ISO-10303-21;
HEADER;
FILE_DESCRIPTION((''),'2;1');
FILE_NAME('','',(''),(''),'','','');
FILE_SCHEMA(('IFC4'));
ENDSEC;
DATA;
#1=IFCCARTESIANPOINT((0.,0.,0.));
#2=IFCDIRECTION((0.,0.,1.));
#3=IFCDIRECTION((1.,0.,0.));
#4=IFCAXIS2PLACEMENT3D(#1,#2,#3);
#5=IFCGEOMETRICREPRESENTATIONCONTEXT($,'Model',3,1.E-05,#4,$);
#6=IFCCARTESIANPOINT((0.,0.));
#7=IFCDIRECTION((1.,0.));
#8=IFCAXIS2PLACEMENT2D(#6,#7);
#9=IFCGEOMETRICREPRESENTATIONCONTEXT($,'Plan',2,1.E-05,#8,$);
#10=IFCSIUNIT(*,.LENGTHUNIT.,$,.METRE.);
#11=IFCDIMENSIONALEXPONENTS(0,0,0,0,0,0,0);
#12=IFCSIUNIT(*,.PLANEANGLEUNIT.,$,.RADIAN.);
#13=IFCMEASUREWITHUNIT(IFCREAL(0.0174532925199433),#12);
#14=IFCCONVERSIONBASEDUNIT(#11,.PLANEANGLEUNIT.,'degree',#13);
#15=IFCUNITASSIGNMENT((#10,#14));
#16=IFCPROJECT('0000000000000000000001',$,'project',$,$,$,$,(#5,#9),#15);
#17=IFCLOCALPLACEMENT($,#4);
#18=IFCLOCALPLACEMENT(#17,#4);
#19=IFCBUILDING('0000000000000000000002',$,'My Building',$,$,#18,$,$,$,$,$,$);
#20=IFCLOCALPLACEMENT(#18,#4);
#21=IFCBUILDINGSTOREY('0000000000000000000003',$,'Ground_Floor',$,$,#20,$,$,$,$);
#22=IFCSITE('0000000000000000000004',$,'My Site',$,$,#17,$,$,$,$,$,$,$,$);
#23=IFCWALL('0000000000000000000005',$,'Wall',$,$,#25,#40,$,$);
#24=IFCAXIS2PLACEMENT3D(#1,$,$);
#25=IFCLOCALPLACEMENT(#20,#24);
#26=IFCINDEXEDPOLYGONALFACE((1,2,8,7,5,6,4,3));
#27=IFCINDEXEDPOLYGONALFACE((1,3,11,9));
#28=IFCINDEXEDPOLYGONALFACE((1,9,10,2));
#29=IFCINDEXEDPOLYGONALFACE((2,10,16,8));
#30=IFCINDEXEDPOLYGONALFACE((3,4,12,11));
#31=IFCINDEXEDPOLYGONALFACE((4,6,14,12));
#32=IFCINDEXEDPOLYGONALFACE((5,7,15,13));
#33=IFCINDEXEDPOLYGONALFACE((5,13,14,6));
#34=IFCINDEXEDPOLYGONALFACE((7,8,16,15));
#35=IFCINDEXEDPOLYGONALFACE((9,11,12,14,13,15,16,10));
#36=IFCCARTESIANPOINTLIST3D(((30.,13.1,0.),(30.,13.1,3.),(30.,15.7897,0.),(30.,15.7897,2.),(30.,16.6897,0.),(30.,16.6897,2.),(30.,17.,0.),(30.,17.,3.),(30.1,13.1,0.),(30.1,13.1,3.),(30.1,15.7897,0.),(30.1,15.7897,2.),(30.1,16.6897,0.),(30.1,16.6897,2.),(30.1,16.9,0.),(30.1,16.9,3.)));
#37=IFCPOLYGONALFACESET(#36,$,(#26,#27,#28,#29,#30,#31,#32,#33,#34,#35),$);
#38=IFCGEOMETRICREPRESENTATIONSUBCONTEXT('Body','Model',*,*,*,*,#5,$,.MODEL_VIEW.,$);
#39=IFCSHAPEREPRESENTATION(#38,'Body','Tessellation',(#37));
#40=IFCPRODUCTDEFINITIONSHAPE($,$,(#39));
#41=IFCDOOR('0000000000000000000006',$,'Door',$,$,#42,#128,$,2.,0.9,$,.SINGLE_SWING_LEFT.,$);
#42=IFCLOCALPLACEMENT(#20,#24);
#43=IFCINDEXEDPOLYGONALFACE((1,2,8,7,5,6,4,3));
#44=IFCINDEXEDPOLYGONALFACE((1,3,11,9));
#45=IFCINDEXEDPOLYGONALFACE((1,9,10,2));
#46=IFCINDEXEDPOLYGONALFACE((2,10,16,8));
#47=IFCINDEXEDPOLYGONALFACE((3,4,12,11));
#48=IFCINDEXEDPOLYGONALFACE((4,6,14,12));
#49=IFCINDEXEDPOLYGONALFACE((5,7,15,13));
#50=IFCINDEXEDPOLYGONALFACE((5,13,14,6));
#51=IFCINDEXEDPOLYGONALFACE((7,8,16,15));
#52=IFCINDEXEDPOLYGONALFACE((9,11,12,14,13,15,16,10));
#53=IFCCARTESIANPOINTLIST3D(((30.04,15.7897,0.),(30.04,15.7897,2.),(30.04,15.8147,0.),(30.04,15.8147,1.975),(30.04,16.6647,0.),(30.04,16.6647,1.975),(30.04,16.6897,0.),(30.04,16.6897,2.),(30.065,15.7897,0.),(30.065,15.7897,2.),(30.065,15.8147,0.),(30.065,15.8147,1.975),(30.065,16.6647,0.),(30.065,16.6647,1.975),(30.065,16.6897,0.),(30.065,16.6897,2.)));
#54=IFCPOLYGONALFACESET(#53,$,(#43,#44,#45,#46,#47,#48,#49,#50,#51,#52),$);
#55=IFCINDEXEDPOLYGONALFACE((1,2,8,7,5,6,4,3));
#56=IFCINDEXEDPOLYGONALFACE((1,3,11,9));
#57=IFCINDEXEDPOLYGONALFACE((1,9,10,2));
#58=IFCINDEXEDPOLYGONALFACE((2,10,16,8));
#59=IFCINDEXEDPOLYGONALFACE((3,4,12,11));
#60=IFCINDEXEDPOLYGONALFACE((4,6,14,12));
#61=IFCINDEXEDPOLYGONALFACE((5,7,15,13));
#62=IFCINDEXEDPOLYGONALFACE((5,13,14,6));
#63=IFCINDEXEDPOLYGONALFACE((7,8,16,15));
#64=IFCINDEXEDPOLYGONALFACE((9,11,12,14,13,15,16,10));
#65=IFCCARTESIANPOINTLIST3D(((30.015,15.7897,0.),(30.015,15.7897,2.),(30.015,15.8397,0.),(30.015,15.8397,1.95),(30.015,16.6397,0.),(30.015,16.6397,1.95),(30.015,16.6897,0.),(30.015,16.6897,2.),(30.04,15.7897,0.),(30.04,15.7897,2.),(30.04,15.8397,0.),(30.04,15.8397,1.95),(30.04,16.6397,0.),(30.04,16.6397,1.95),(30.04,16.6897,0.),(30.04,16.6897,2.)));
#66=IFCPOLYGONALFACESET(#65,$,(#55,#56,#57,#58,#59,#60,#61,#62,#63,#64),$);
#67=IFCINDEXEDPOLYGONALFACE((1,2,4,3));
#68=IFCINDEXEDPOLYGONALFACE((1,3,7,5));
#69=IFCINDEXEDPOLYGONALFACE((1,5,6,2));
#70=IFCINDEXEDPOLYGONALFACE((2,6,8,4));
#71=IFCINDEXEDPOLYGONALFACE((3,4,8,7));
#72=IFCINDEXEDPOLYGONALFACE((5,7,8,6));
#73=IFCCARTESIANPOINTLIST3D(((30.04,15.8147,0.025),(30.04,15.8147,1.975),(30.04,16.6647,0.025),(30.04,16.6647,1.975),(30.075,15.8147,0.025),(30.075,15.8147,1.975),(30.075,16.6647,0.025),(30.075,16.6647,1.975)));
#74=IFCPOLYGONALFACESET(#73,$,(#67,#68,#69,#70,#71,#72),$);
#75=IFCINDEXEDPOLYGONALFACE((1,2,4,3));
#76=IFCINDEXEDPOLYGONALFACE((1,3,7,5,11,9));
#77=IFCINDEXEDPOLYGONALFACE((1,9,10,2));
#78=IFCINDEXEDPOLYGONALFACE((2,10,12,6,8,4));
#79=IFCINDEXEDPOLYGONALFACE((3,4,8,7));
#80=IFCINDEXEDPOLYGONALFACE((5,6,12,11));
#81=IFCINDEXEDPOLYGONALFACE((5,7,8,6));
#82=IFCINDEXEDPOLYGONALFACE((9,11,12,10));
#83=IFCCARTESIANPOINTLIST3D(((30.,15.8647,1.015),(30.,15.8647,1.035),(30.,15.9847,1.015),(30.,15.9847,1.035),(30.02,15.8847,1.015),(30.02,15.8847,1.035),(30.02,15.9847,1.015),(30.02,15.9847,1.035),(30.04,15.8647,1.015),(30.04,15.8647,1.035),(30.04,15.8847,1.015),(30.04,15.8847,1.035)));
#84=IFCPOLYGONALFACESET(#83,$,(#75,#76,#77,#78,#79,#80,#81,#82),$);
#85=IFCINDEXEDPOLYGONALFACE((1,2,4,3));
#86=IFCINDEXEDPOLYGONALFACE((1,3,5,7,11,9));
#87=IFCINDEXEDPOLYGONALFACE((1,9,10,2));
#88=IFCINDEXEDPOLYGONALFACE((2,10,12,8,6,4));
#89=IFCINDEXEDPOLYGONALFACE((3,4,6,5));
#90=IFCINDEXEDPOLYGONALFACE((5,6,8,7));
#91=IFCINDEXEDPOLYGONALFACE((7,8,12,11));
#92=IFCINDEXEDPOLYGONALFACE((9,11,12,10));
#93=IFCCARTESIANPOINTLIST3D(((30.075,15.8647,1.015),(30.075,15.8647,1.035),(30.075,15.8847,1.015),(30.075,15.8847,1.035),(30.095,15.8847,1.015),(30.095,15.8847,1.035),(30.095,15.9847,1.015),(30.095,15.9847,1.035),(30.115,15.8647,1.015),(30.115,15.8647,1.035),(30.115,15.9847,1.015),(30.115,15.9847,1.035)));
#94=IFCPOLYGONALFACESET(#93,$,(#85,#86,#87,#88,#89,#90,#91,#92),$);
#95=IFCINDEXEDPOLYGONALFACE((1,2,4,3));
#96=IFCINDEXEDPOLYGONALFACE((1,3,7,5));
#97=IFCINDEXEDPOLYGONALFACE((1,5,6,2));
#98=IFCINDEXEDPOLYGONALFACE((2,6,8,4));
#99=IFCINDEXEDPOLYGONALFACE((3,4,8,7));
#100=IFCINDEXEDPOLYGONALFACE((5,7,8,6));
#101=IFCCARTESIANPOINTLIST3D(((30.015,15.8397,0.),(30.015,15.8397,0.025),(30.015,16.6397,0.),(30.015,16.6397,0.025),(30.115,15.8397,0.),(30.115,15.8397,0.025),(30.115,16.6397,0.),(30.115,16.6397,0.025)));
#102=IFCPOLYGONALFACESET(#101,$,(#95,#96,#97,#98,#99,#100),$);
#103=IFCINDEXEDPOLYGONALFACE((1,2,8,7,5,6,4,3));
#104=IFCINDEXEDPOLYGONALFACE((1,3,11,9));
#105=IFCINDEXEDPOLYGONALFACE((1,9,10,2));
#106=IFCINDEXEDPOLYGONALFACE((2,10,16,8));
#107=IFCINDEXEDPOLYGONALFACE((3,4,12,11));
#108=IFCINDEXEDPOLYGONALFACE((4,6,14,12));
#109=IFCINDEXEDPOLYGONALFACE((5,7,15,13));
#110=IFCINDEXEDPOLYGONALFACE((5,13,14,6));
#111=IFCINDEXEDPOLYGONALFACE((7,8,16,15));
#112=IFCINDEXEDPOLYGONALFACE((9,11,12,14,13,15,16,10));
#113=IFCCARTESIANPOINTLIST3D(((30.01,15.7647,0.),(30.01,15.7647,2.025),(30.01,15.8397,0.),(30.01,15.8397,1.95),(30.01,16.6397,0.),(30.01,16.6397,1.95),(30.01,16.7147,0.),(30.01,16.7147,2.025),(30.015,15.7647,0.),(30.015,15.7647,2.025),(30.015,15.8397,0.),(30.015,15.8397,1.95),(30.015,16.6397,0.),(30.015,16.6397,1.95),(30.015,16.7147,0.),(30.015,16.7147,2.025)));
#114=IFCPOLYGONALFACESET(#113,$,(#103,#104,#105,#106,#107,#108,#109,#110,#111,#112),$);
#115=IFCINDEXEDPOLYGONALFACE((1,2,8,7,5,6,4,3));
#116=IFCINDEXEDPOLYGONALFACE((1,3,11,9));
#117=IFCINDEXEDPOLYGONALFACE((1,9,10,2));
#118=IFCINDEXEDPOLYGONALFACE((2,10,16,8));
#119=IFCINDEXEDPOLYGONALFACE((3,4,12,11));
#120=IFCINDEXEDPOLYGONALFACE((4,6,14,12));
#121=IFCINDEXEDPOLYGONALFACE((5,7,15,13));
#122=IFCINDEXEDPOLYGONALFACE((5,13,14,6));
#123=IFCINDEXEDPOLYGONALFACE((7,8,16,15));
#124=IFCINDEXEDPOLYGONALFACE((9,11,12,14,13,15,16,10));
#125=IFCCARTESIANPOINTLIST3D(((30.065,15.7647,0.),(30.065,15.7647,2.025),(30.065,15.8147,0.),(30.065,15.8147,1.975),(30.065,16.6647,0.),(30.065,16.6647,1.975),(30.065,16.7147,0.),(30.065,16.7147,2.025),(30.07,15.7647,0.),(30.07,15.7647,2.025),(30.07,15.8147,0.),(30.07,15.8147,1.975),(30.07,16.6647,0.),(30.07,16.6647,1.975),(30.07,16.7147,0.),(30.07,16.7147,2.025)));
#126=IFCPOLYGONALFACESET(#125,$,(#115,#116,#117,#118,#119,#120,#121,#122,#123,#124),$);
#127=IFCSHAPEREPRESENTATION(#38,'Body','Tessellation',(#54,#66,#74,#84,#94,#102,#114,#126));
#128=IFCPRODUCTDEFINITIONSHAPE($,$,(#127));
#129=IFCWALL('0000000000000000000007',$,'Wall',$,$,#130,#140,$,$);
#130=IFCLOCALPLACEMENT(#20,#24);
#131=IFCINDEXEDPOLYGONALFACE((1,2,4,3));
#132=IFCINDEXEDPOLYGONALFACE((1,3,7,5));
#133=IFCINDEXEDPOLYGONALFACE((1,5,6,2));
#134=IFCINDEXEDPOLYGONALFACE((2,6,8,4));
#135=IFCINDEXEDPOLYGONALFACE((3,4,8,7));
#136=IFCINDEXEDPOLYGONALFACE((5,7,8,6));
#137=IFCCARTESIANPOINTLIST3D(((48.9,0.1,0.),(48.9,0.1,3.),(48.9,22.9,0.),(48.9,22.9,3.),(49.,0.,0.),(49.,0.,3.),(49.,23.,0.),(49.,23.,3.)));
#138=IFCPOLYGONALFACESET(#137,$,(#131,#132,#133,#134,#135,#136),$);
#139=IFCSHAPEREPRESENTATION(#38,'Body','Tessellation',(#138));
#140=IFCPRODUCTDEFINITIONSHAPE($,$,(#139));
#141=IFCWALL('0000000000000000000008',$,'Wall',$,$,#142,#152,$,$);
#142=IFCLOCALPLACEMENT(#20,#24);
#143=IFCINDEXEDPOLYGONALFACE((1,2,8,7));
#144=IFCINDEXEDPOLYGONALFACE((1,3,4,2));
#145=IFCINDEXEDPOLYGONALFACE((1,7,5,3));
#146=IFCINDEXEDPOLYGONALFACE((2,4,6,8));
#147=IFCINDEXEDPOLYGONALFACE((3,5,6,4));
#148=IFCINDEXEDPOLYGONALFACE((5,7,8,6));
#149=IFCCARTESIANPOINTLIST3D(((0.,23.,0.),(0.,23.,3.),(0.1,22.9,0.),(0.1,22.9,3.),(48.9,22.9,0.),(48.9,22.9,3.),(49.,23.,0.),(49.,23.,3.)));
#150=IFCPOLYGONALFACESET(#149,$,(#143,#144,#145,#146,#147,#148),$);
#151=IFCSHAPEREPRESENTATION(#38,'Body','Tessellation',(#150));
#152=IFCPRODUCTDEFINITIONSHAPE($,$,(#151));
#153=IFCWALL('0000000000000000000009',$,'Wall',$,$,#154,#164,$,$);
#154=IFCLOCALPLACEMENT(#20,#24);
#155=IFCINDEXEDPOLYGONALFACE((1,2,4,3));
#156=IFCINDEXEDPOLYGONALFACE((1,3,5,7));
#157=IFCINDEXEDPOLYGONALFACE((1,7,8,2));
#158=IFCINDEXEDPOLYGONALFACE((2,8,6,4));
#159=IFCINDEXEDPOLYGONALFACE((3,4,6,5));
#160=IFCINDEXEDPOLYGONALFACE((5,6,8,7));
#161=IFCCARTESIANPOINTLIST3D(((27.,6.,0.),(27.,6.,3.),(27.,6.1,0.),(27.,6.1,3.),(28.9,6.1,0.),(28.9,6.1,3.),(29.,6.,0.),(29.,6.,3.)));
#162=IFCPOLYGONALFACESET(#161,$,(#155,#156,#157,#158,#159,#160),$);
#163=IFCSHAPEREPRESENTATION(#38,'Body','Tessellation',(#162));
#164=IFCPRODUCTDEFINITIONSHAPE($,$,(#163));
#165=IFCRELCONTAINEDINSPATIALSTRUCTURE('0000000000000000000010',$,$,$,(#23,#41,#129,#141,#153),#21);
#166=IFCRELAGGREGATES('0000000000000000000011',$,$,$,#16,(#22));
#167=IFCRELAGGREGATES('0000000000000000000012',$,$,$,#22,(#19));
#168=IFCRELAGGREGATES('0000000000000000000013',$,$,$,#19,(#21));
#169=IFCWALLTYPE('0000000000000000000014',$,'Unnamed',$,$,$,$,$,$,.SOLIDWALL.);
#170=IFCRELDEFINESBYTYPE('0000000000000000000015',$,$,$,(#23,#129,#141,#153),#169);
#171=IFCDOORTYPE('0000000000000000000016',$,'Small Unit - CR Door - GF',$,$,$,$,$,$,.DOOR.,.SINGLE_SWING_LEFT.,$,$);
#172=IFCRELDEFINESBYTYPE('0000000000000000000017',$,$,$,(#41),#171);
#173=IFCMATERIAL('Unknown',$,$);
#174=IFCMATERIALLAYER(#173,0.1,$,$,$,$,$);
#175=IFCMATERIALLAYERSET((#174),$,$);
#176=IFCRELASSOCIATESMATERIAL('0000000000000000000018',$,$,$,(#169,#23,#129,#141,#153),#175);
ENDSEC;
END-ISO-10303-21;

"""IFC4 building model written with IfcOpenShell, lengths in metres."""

from ifc_helpers import new_model, entity, si_unit, converted_unit, frame, origin_with_axes, origin_2d_with_axis, place, context, subcontext, project, spatial, line, indexed_curve, outline, extrude, shape, source, transform, mapped, material, layer, layer_set, layer_usage, type_object, type_shapes, element, fill, save


model = new_model("IFC4")

# Units and contexts
model_context = context("Model", 3, precision=1e-05, world=origin_with_axes())
plan_context = context("Plan", 2, precision=1e-05, world=origin_2d_with_axis())
body_context_1 = subcontext(model_context, "Body", "Model", "MODEL_VIEW")
body_context_2 = subcontext(plan_context, "Body", "Plan", "PLAN_VIEW")
ifc_project = project(units=[si_unit("LENGTHUNIT", "METRE"), converted_unit("PLANEANGLEUNIT", "degree", entity("IfcReal", 0.0174532925199433), si_unit("PLANEANGLEUNIT", "RADIAN"), dimensions=[0, 0, 0, 0, 0, 0, 0])], contexts=[model_context, plan_context])

# Site, building, storey
site_placement = place(None, origin_with_axes())
site = spatial("IfcSite", under=ifc_project, at=site_placement, Name="My Site")
building_placement = place(site_placement, origin_with_axes())
building = spatial("IfcBuilding", under=site, at=building_placement, Name="My Building")
storey_placement = place(building_placement, origin_with_axes())
storey = spatial("IfcBuildingStorey", under=building, at=storey_placement, Name="Ground_Floor")

# Shared definitions
ifc_material = material(Name="Unknown")
ifc_layer = layer(ifc_material, 0.1)
ifc_layer_set = layer_set([ifc_layer])
wall_type = type_object("IfcWallType", Name="Unnamed", PredefinedType="SOLIDWALL", material=ifc_layer_set)

# Shared definitions
shared_shape_1 = source(origin_with_axes(), body_context_1, "Body", "SweptSolid", [
    extrude(outline(indexed_curve([(0.0, 0.0), (0.9, 0.0), (0.9, 2.0), (0.0, 2.0)], segments=[line(1, 2, 3, 4, 1)])), frame((0.0, -0.6, 0.0), z_axis=(0.0, -1.0, 0.0), x_axis=(1.0, 0.0, 0.0)), (0.0, 0.0, -1.0), 1.2),
])
door_type_1 = type_object("IfcDoorType", Name="Small Unit - CR Door - GF", OperationType="SINGLE_SWING_LEFT", PredefinedType="DOOR")
shared_shape_2 = source(origin_with_axes(), body_context_1, "Body", "SweptSolid", [
    extrude(outline(indexed_curve([(0.0, 0.0), (0.0, 2.0), (0.9, 2.0), (0.9, 0.0), (0.875, 0.0), (0.875, 1.975), (0.025, 1.975), (0.025, 0.0)], segments=[line(1, 2, 3, 4, 5, 6, 7, 8, 1)])), frame((0.0, 0.025, 0.0), z_axis=(0.0, -1.0, 0.0), x_axis=(1.0, 0.0, 0.0)), (0.0, 0.0, -1.0), 0.025),
    extrude(outline(indexed_curve([(0.0, 0.0), (0.0, 2.0), (0.9, 2.0), (0.9, 0.0), (0.85, 0.0), (0.85, 1.95), (0.05, 1.95), (0.05, 0.0)], segments=[line(1, 2, 3, 4, 5, 6, 7, 8, 1)])), frame((0.0, 0.0, 0.0), z_axis=(0.0, -1.0, 0.0), x_axis=(1.0, 0.0, 0.0)), (0.0, 0.0, -1.0), 0.025),
    extrude(outline(indexed_curve([(0.0, 0.0), (0.85, 0.0), (0.85, 0.035), (0.0, 0.035)], segments=[line(1, 2, 3, 4, 1)])), frame((0.025, 0.025, 0.025), z_axis=(0.0, 0.0, 1.0), x_axis=(1.0, 0.0, 0.0)), (0.0, 0.0, 1.0), 1.95),
    extrude(outline(indexed_curve([(0.0, 0.0), (0.0, -0.04), (-0.12, -0.04), (-0.12, -0.02), (-0.02, -0.02), (-0.02, 0.0)], segments=[line(1, 2, 3, 4, 5, 6, 1)])), frame((0.825, 0.025, 1.015), z_axis=(0.0, 0.0, 1.0), x_axis=(1.0, 0.0, 0.0)), (0.0, 0.0, 1.0), 0.02),
    extrude(outline(indexed_curve([(0.0, 0.0), (0.0, 0.04), (-0.12, 0.04), (-0.12, 0.02), (-0.02, 0.02), (-0.02, 0.0)], segments=[line(1, 2, 3, 4, 5, 6, 1)])), frame((0.825, 0.06, 1.015), z_axis=(0.0, 0.0, 1.0), x_axis=(1.0, 0.0, 0.0)), (0.0, 0.0, 1.0), 0.02),
    extrude(outline(indexed_curve([(0.0, 0.0), (0.8, 0.0), (0.8, 0.1), (0.0, 0.1)], segments=[line(1, 2, 3, 4, 1)])), frame((0.05, 0.0, 0.0), z_axis=(0.0, 0.0, 1.0), x_axis=(1.0, 0.0, 0.0)), (0.0, 0.0, 1.0), 0.025),
    extrude(outline(indexed_curve([(0.0, 0.0), (0.0, 2.025), (0.95, 2.025), (0.95, 0.0), (0.875, 0.0), (0.875, 1.95), (0.075, 1.95), (0.075, 0.0)], segments=[line(1, 2, 3, 4, 5, 6, 7, 8, 1)])), frame((-0.025, -0.005, 0.0), z_axis=(0.0, -1.0, 0.0), x_axis=(1.0, 0.0, 0.0)), (0.0, 0.0, -1.0), 0.005),
    extrude(outline(indexed_curve([(0.0, 0.0), (0.0, 2.025), (0.95, 2.025), (0.95, 0.0), (0.9, 0.0), (0.9, 1.975), (0.05, 1.975), (0.05, 0.0)], segments=[line(1, 2, 3, 4, 5, 6, 7, 8, 1)])), frame((-0.025, 0.05, 0.0), z_axis=(0.0, -1.0, 0.0), x_axis=(1.0, 0.0, 0.0)), (0.0, 0.0, -1.0), 0.005),
])
shared_shape_3 = source(origin_with_axes(), body_context_2, "Body", "Curve2D", [
    entity("IfcIndexedPolyCurve", entity("IfcCartesianPointList2D", [[0.0, 0.0], [0.0, 0.05], [0.025, 0.05], [0.025, 0.025], [0.05, 0.025], [0.05, 0.0]]), [entity("IfcLineIndex", [1, 2, 3, 4, 5, 6, 1])]),
    entity("IfcIndexedPolyCurve", entity("IfcCartesianPointList2D", [[0.9, 0.0], [0.9, 0.05], [0.875, 0.05], [0.875, 0.025], [0.85, 0.025], [0.85, 0.0]]), [entity("IfcLineIndex", [1, 2, 3, 4, 5, 6, 1])]),
    entity("IfcTrimmedCurve", entity("IfcEllipse", entity("IfcAxis2Placement2D", entity("IfcCartesianPoint", [0.06, 0.05]), entity("IfcDirection", [1.0, 0.0])), 0.815, 0.85), [entity("IfcCartesianPoint", [0.875, 0.05])], [entity("IfcCartesianPoint", [0.06, 0.9])], True, "CARTESIAN"),
    entity("IfcIndexedPolyCurve", entity("IfcCartesianPointList2D", [[0.025, 0.05], [0.06, 0.05], [0.06, 0.9], [0.025, 0.9]]), [entity("IfcLineIndex", [1, 2, 3, 4, 1])]),
])
type_shapes(door_type_1, [shared_shape_2, shared_shape_3])

# Wall, opening, door
ifc_layer_usage_1 = layer_usage(ifc_layer_set, "AXIS2", "POSITIVE", 0.0)
wall_1_placement = place(storey_placement, frame((30.0, 17.0, 0.0), z_axis=(0.0, 0.0, 1.0), x_axis=(0.0, -1.0, 0.0)))
wall_1 = element("IfcWall", 1, at=wall_1_placement, inside=storey, type_object=wall_type, material=ifc_layer_usage_1, Name="Wall", context=body_context_1, shape_type="SweptSolid", body=[
    extrude(outline(indexed_curve([(0.0, 0.0), (0.1, 0.1), (3.9, 0.1), (3.9, 0.0)], segments=[line(1, 2, 3, 4, 1)])), origin_with_axes(), (0.0, 0.0, 1.0), 3.0),
])
opening_1_placement = place(wall_1_placement, frame((0.3103, 0.015, 0.0), z_axis=(0.0, 0.0, 1.0), x_axis=(1.0, 0.0, 0.0)))
opening_1 = element("IfcOpeningElement", 2, at=opening_1_placement, cuts=wall_1, PredefinedType="OPENING", context=body_context_1, shape_type="MappedRepresentation", body=[
    mapped(shared_shape_1, transform((0.0, 0.0, 0.0), x_axis=(1.0, 0.0, 0.0), y_axis=(0.0, 1.0, 0.0), z_axis=(0.0, 0.0, 1.0), scale=1.0)),
])
door_1_placement = place(opening_1_placement, frame((0.0, 0.0, 0.0), z_axis=(0.0, 0.0, 1.0), x_axis=(1.0, 0.0, 0.0)))
door_1 = element("IfcDoor", 3, at=door_1_placement, inside=storey, type_object=door_type_1, Name="Door", OperationType="SINGLE_SWING_LEFT", OverallHeight=2.0, OverallWidth=0.9, shapes=[
    shape(body_context_1, "Body", "MappedRepresentation", [mapped(shared_shape_2, transform((0.0, 0.0, 0.0), x_axis=(1.0, 0.0, 0.0), y_axis=(0.0, 1.0, 0.0), z_axis=(0.0, 0.0, 1.0), scale=1.0))]),
    shape(body_context_2, "Body", "MappedRepresentation", [mapped(shared_shape_3, transform((0.0, 0.0, 0.0), x_axis=(1.0, 0.0, 0.0), y_axis=(0.0, 1.0, 0.0), z_axis=(0.0, 0.0, 1.0), scale=1.0))]),
])
fill(opening_1, door_1)

# Walls
ifc_layer_usage_2 = layer_usage(ifc_layer_set, "AXIS2", "POSITIVE", 0.0)
wall_2_placement = place(storey_placement, frame((49.0, 0.0, 0.0), z_axis=(0.0, 0.0, 1.0), x_axis=(0.0, 1.0, 0.0)))
element("IfcWall", 4, at=wall_2_placement, inside=storey, type_object=wall_type, material=ifc_layer_usage_2, Name="Wall", context=body_context_1, shape_type="SweptSolid", body=[
    extrude(outline(indexed_curve([(0.0, 0.0), (0.1, 0.1), (22.9, 0.1), (23.0, 0.0)], segments=[line(1, 2, 3, 4, 1)])), origin_with_axes(), (0.0, 0.0, 1.0), 3.0),
])
ifc_layer_usage_3 = layer_usage(ifc_layer_set, "AXIS2", "POSITIVE", 0.0)
wall_3_placement = place(storey_placement, frame((49.0, 23.0, 0.0), z_axis=(0.0, 0.0, 1.0), x_axis=(-1.0, 0.0, 0.0)))
element("IfcWall", 5, at=wall_3_placement, inside=storey, type_object=wall_type, material=ifc_layer_usage_3, Name="Wall", context=body_context_1, shape_type="SweptSolid", body=[
    extrude(outline(indexed_curve([(0.0, 0.0), (0.1, 0.1), (48.9, 0.1), (49.0, 0.0)], segments=[line(1, 2, 3, 4, 1)])), origin_with_axes(), (0.0, 0.0, 1.0), 3.0),
])
ifc_layer_usage_4 = layer_usage(ifc_layer_set, "AXIS2", "POSITIVE", 0.0)
wall_4_placement = place(storey_placement, frame((27.0, 6.0, 0.0), z_axis=(0.0, 0.0, 1.0), x_axis=(1.0, 0.0, 0.0)))
element("IfcWall", 6, at=wall_4_placement, inside=storey, type_object=wall_type, material=ifc_layer_usage_4, Name="Wall", context=body_context_1, shape_type="SweptSolid", body=[
    extrude(outline(indexed_curve([(0.0, 0.0), (0.0, 0.1), (1.9, 0.1), (2.0, 0.0)], segments=[line(1, 2, 3, 4, 1)])), origin_with_axes(), (0.0, 0.0, 1.0), 3.0),
])

save(model, "model.ifc")
